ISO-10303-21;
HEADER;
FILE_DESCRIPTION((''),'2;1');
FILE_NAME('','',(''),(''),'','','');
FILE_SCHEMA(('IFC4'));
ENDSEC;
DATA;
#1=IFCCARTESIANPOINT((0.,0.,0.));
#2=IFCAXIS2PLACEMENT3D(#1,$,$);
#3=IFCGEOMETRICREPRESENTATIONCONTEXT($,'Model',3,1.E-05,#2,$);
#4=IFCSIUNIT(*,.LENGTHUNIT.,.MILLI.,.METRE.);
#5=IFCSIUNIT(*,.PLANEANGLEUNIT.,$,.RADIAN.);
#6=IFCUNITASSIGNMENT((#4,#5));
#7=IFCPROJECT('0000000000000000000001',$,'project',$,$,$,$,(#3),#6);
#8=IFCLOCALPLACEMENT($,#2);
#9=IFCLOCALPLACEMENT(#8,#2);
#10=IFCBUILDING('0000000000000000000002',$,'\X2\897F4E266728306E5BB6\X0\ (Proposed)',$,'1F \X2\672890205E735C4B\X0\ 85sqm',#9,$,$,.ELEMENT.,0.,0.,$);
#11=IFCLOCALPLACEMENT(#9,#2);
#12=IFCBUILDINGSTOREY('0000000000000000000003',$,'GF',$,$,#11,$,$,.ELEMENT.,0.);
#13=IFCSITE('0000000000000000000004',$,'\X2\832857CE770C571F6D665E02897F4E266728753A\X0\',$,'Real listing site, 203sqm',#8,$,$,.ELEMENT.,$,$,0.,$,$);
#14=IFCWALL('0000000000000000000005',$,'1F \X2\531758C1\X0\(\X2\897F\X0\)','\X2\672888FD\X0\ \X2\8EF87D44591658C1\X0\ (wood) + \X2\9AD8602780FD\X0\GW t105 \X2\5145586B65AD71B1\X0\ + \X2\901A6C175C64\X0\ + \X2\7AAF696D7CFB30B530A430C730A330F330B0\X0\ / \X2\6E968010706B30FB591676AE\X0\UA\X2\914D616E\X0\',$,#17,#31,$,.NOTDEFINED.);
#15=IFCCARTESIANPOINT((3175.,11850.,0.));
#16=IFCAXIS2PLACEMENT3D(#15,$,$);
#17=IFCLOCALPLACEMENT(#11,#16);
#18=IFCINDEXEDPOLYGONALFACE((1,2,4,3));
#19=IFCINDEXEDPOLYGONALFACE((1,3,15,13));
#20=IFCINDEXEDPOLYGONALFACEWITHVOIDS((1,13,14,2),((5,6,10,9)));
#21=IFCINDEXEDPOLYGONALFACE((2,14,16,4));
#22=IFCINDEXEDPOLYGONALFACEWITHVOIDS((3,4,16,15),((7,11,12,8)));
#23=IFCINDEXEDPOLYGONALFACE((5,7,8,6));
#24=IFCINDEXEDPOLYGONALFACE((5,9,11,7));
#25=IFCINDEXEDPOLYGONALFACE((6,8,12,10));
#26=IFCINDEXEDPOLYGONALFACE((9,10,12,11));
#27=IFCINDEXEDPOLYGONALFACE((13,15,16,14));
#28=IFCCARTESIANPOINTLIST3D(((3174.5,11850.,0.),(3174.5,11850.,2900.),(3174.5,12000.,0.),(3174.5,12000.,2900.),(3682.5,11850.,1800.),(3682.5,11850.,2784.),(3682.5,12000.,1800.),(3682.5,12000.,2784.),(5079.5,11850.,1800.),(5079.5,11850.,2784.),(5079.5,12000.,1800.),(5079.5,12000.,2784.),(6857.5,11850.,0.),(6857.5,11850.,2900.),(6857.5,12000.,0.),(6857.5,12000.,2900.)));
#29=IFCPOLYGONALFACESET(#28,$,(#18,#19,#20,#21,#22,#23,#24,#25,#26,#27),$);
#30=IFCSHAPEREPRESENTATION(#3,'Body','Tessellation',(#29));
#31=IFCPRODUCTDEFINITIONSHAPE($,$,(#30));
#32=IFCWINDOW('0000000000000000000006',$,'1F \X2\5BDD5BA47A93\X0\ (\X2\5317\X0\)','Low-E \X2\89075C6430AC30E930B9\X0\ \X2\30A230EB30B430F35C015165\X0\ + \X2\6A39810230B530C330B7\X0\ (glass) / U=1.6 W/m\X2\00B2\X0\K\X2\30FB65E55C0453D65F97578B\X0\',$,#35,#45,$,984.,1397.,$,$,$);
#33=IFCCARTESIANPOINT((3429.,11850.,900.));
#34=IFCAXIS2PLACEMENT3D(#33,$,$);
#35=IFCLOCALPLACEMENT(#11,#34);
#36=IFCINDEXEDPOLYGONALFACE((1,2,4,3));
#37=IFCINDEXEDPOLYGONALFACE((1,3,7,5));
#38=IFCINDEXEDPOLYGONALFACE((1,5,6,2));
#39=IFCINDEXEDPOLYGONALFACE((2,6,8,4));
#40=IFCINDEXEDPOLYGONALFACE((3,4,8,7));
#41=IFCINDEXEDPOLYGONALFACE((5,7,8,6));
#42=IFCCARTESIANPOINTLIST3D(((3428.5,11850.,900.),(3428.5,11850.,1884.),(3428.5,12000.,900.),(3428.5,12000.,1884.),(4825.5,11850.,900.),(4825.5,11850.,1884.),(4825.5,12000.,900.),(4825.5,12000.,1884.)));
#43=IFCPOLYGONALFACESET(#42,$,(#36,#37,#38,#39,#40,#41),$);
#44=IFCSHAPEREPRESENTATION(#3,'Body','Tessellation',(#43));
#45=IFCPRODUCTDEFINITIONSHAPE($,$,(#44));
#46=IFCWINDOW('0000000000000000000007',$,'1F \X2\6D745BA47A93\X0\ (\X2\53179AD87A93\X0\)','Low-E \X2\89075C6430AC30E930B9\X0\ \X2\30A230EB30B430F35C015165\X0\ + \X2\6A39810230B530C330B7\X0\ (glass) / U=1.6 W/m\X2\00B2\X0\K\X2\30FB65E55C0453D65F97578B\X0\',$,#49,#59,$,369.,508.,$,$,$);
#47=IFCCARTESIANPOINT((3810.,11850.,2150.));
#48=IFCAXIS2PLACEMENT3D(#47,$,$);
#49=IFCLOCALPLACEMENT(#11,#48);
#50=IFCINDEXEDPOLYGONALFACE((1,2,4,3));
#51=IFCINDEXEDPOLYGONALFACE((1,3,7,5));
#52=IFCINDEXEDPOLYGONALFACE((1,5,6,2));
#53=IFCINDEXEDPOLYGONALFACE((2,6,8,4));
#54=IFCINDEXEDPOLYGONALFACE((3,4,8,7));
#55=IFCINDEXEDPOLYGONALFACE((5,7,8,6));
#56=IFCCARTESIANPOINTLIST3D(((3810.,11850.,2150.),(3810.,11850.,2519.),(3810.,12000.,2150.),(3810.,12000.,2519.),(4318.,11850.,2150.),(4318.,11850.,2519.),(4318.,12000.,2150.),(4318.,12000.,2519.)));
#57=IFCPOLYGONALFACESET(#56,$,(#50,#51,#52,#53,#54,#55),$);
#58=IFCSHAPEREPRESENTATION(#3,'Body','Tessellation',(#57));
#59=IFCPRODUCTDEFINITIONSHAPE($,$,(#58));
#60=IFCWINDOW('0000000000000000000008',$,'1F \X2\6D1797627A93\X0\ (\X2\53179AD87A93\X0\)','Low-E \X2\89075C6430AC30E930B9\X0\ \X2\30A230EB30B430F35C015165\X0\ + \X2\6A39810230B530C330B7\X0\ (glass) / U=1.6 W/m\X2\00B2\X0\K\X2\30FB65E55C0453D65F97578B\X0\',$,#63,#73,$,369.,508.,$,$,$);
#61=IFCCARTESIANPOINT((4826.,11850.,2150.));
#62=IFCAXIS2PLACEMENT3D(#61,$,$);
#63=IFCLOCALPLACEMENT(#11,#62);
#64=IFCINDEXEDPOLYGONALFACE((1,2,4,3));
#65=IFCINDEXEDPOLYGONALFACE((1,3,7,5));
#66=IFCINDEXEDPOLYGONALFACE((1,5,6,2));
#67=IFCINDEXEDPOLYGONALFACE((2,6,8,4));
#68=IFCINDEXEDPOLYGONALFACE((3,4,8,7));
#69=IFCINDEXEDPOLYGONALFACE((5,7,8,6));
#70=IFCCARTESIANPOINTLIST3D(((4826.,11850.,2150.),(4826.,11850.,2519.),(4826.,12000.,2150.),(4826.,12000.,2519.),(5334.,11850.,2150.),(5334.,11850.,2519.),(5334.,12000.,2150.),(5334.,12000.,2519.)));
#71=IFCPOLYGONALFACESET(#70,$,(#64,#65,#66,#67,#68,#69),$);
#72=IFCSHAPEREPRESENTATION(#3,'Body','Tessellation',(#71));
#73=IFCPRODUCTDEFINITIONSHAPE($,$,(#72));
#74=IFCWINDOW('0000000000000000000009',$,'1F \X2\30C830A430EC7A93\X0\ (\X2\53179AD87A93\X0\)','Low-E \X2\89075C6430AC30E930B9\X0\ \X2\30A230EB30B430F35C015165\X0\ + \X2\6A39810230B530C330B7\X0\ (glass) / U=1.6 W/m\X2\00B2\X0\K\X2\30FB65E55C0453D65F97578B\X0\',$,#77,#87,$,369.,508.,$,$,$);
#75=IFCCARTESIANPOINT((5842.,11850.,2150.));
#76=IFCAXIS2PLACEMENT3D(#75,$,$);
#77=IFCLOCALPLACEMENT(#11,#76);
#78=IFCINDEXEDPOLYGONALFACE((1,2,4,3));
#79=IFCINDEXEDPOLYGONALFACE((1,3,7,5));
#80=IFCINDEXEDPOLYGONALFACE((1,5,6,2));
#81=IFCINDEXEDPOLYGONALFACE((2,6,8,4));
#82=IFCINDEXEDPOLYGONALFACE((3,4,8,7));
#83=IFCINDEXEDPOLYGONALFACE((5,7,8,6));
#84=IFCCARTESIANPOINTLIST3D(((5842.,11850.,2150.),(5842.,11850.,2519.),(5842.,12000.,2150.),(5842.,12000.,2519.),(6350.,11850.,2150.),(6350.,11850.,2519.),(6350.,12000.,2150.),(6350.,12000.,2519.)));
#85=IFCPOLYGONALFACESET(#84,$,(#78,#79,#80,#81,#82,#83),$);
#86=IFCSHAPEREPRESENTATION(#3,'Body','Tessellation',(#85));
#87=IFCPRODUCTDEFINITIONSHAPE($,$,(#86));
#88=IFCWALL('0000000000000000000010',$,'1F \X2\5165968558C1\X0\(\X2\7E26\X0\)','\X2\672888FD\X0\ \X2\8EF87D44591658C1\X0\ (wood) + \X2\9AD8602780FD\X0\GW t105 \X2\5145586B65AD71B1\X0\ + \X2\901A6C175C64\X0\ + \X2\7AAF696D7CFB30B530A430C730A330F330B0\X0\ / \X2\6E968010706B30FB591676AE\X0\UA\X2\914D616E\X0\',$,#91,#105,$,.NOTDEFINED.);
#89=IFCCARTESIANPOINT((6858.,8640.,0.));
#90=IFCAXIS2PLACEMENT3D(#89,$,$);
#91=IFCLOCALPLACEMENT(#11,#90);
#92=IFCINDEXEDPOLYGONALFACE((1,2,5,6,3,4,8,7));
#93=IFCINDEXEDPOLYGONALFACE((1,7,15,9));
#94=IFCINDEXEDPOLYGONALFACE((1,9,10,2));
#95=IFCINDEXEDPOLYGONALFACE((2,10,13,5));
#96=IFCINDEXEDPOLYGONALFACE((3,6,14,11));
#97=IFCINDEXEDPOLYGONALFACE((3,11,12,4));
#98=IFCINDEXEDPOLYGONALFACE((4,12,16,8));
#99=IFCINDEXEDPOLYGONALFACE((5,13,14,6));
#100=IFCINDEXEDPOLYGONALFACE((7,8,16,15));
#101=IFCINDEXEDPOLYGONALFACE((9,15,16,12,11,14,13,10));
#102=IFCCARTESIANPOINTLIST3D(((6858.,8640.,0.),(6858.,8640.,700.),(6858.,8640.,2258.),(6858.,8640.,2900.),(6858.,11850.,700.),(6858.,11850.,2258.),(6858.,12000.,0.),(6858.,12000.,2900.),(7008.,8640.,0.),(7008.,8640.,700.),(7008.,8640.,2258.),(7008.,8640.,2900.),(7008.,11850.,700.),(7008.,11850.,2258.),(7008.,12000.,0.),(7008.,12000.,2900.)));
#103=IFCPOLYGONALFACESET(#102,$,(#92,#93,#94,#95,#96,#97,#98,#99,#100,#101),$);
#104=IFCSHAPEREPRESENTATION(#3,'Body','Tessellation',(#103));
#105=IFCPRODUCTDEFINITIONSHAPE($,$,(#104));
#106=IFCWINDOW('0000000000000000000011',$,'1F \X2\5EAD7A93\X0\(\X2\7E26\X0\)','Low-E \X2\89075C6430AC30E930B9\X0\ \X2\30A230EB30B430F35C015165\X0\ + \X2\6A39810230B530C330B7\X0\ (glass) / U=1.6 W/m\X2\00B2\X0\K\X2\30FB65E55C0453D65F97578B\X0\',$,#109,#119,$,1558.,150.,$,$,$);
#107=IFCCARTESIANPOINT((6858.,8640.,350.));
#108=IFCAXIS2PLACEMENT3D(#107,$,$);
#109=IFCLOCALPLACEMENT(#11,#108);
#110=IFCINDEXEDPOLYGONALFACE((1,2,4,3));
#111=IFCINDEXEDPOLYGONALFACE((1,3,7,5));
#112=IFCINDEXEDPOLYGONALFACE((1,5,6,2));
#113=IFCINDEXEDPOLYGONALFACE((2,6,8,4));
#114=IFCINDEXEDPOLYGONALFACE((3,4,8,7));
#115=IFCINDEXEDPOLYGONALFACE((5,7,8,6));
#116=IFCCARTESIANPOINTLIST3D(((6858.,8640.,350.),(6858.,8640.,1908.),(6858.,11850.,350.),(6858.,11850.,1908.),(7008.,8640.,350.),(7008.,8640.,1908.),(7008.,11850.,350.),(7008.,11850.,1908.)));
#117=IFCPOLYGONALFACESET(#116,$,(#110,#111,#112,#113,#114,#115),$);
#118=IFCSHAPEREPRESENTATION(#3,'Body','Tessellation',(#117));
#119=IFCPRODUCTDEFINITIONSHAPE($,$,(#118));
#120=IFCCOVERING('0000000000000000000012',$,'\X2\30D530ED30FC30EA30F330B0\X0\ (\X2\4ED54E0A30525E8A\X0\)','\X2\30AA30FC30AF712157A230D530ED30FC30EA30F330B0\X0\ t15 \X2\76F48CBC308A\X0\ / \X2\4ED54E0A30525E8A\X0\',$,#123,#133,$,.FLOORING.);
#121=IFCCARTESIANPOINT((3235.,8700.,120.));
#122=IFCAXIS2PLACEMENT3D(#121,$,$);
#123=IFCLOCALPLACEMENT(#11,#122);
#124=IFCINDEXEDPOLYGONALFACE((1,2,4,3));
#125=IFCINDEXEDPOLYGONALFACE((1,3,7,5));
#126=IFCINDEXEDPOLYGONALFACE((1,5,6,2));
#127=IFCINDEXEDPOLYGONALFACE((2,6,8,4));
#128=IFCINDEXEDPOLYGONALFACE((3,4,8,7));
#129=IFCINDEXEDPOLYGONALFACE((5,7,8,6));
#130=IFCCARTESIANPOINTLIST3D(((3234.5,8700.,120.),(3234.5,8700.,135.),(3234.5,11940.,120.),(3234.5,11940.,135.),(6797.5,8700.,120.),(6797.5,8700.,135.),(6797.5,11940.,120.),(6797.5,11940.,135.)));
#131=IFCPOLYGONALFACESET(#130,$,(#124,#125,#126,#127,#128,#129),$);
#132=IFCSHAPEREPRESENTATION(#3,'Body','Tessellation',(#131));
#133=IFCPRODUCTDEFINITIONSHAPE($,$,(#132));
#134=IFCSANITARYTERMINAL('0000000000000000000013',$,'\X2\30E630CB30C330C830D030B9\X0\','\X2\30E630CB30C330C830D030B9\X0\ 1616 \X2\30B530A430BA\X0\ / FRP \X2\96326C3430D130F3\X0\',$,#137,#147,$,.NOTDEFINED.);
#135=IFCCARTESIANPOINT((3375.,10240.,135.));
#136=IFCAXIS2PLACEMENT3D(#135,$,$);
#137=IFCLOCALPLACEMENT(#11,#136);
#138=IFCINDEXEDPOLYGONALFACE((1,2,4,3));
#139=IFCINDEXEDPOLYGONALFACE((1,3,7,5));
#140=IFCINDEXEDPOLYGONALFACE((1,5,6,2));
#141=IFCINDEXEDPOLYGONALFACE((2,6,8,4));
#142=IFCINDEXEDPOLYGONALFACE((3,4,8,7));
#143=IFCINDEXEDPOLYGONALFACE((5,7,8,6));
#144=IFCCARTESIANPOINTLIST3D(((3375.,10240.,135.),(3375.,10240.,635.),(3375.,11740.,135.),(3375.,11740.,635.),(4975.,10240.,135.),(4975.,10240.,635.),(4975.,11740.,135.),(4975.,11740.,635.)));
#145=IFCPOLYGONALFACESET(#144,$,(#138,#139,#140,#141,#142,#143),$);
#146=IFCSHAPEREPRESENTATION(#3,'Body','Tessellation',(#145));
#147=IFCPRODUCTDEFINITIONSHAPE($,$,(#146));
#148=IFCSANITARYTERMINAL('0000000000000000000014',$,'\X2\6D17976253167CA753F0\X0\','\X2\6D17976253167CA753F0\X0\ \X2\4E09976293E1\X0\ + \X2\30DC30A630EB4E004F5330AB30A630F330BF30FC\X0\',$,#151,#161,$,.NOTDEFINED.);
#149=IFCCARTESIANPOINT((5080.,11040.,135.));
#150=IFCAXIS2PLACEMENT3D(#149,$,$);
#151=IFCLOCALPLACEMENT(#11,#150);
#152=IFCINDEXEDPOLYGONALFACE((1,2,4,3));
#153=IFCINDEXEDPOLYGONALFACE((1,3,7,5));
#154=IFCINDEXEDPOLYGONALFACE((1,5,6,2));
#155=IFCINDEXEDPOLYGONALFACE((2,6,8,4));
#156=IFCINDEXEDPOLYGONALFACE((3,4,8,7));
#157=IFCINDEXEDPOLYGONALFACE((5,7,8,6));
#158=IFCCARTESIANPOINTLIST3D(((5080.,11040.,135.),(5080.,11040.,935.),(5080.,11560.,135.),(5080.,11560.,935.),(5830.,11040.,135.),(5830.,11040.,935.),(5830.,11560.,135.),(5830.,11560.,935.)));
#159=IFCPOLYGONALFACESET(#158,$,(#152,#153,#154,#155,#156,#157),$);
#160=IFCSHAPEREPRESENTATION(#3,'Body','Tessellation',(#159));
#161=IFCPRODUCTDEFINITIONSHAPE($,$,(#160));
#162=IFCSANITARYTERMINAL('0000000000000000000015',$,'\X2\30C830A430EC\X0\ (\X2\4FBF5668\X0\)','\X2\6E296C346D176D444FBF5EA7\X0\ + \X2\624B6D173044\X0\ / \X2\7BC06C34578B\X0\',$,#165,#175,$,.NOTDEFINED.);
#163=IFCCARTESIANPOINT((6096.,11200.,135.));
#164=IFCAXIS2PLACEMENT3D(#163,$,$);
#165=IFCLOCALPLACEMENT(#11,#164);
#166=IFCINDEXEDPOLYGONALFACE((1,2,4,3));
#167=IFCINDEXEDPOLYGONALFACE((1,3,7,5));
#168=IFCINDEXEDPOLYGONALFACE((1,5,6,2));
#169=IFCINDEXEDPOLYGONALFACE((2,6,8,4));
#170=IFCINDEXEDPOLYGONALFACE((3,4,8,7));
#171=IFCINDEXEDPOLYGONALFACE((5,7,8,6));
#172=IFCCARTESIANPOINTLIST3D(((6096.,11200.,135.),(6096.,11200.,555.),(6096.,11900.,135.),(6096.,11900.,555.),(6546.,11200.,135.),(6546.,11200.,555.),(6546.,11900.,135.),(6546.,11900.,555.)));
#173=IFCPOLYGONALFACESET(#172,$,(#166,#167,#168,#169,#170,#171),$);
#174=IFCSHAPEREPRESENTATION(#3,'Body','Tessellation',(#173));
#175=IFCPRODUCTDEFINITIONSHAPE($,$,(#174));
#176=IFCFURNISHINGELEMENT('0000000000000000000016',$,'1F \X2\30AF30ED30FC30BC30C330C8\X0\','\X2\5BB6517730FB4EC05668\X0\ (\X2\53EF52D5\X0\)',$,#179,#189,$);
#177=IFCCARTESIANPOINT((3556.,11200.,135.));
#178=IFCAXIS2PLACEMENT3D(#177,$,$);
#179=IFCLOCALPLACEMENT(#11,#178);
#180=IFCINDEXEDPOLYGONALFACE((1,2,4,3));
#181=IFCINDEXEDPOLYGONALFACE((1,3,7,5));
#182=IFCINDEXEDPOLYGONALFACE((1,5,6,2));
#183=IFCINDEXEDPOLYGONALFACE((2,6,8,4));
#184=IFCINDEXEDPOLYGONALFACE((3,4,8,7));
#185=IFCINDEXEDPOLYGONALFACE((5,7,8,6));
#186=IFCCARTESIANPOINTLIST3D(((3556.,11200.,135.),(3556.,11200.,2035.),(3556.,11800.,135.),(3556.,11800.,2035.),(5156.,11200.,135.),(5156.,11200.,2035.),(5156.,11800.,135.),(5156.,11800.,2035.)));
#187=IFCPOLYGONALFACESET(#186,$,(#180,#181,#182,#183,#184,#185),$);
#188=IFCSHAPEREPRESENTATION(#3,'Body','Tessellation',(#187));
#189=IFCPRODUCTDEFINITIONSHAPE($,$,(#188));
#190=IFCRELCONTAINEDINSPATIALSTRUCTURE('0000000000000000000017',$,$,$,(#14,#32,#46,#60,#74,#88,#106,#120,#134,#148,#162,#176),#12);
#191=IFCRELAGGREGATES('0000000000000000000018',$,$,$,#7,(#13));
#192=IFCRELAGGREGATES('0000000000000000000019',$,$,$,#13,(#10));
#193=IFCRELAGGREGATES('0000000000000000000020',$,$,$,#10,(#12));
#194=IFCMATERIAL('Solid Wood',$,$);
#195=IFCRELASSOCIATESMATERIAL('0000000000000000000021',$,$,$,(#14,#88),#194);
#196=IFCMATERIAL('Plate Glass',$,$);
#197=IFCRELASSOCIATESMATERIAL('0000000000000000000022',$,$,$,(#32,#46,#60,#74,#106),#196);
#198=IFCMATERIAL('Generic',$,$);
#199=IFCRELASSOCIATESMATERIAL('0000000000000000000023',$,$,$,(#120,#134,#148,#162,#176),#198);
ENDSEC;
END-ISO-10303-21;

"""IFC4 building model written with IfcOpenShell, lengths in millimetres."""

from ifc_helpers import new_model, si_unit, frame, frame_2d, origin, place, context, project, spatial, rectangle, extrude, material, element, fill, save


model = new_model("IFC4")

# Units and contexts
model_context = context("Model", 3, precision=1e-05, world=origin())
ifc_project = project(units=[si_unit("LENGTHUNIT", "METRE", prefix="MILLI"), si_unit("PLANEANGLEUNIT", "RADIAN")], contexts=[model_context])

# Site, building, storey
site_placement = place(None, origin())
site = spatial("IfcSite", under=ifc_project, at=site_placement, Name="茨城県土浦市西並木町", ObjectType="Real listing site, 203sqm", CompositionType="ELEMENT", RefElevation=0.0)
building_placement = place(site_placement, origin())
building = spatial("IfcBuilding", under=site, at=building_placement, Name="西並木の家 (Proposed)", ObjectType="1F 木造平屋 85sqm", CompositionType="ELEMENT", ElevationOfRefHeight=0.0, ElevationOfTerrain=0.0)
storey_placement = place(building_placement, origin())
storey = spatial("IfcBuildingStorey", under=building, at=storey_placement, Name="GF", CompositionType="ELEMENT", Elevation=0.0)

# Shared definitions
ifc_material_1 = material(Name="Solid Wood")

# Wall, openings, windows
wall_1_placement = place(storey_placement, frame((3175.0, 11850.0, 0.0)))
wall_1 = element("IfcWall", 1, at=wall_1_placement, inside=storey, material=ifc_material_1, Name="1F 北壁(西)", Description="木製 軸組外壁 (wood) + 高性能GW t105 充填断熱 + 通気層 + 窯業系サイディング / 準耐火・外皮UA配慮", PredefinedType="NOTDEFINED", context=model_context, shape_type="SweptSolid", body=[
    extrude(rectangle(XDim=3683.0, YDim=150.0, at=frame_2d((1841.0, 75.0))), frame((3175.0, 11850.0, 0.0)), (0.0, 0.0, 1.0), 2900.0),
])
opening_1_placement = place(storey_placement, frame((3429.0, 11850.0, 900.0)))
opening_1 = element("IfcOpeningElement", 2, at=opening_1_placement, cuts=wall_1, PredefinedType="NOTDEFINED", context=model_context, shape_type="SweptSolid", body=[
    extrude(rectangle(XDim=1397.0, YDim=150.0, at=frame_2d((698.0, 75.0))), frame((3429.0, 11850.0, 900.0)), (0.0, 0.0, 1.0), 984.0),
])
opening_2_placement = place(storey_placement, frame((3810.0, 11850.0, 2150.0)))
opening_2 = element("IfcOpeningElement", 3, at=opening_2_placement, cuts=wall_1, PredefinedType="NOTDEFINED", context=model_context, shape_type="SweptSolid", body=[
    extrude(rectangle(XDim=508.0, YDim=150.0, at=frame_2d((254.0, 75.0))), frame((3810.0, 11850.0, 2150.0)), (0.0, 0.0, 1.0), 369.0),
])
opening_3_placement = place(storey_placement, frame((4826.0, 11850.0, 2150.0)))
opening_3 = element("IfcOpeningElement", 4, at=opening_3_placement, cuts=wall_1, PredefinedType="NOTDEFINED", context=model_context, shape_type="SweptSolid", body=[
    extrude(rectangle(XDim=508.0, YDim=150.0, at=frame_2d((254.0, 75.0))), frame((4826.0, 11850.0, 2150.0)), (0.0, 0.0, 1.0), 369.0),
])
opening_4_placement = place(storey_placement, frame((5842.0, 11850.0, 2150.0)))
opening_4 = element("IfcOpeningElement", 5, at=opening_4_placement, cuts=wall_1, PredefinedType="NOTDEFINED", context=model_context, shape_type="SweptSolid", body=[
    extrude(rectangle(XDim=508.0, YDim=150.0, at=frame_2d((254.0, 75.0))), frame((5842.0, 11850.0, 2150.0)), (0.0, 0.0, 1.0), 369.0),
])
ifc_material_2 = material(Name="Plate Glass")
window_1_placement = place(storey_placement, frame((3429.0, 11850.0, 900.0)))
window_1 = element("IfcWindow", 6, at=window_1_placement, inside=storey, material=ifc_material_2, Name="1F 寝室窓 (北)", Description="Low-E 複層ガラス アルゴン封入 + 樹脂サッシ (glass) / U=1.6 W/m²K・日射取得型", OverallHeight=984.0, OverallWidth=1397.0, context=model_context, shape_type="SweptSolid", body=[
    extrude(rectangle(XDim=1397.0, YDim=150.0, at=frame_2d((698.0, 75.0))), frame((3429.0, 11850.0, 900.0)), (0.0, 0.0, 1.0), 984.0),
])
fill(opening_1, window_1)
window_2_placement = place(storey_placement, frame((3810.0, 11850.0, 2150.0)))
window_2 = element("IfcWindow", 7, at=window_2_placement, inside=storey, material=ifc_material_2, Name="1F 浴室窓 (北高窓)", Description="Low-E 複層ガラス アルゴン封入 + 樹脂サッシ (glass) / U=1.6 W/m²K・日射取得型", OverallHeight=369.0, OverallWidth=508.0, context=model_context, shape_type="SweptSolid", body=[
    extrude(rectangle(XDim=508.0, YDim=150.0, at=frame_2d((254.0, 75.0))), frame((3810.0, 11850.0, 2150.0)), (0.0, 0.0, 1.0), 369.0),
])
fill(opening_2, window_2)
window_3_placement = place(storey_placement, frame((4826.0, 11850.0, 2150.0)))
window_3 = element("IfcWindow", 8, at=window_3_placement, inside=storey, material=ifc_material_2, Name="1F 洗面窓 (北高窓)", Description="Low-E 複層ガラス アルゴン封入 + 樹脂サッシ (glass) / U=1.6 W/m²K・日射取得型", OverallHeight=369.0, OverallWidth=508.0, context=model_context, shape_type="SweptSolid", body=[
    extrude(rectangle(XDim=508.0, YDim=150.0, at=frame_2d((254.0, 75.0))), frame((4826.0, 11850.0, 2150.0)), (0.0, 0.0, 1.0), 369.0),
])
fill(opening_3, window_3)
window_4_placement = place(storey_placement, frame((5842.0, 11850.0, 2150.0)))
window_4 = element("IfcWindow", 9, at=window_4_placement, inside=storey, material=ifc_material_2, Name="1F トイレ窓 (北高窓)", Description="Low-E 複層ガラス アルゴン封入 + 樹脂サッシ (glass) / U=1.6 W/m²K・日射取得型", OverallHeight=369.0, OverallWidth=508.0, context=model_context, shape_type="SweptSolid", body=[
    extrude(rectangle(XDim=508.0, YDim=150.0, at=frame_2d((254.0, 75.0))), frame((5842.0, 11850.0, 2150.0)), (0.0, 0.0, 1.0), 369.0),
])
fill(opening_4, window_4)

# Wall, opening, window
wall_2_placement = place(storey_placement, frame((6858.0, 8640.0, 0.0)))
wall_2 = element("IfcWall", 10, at=wall_2_placement, inside=storey, material=ifc_material_1, Name="1F 入隅壁(縦)", Description="木製 軸組外壁 (wood) + 高性能GW t105 充填断熱 + 通気層 + 窯業系サイディング / 準耐火・外皮UA配慮", PredefinedType="NOTDEFINED", context=model_context, shape_type="SweptSolid", body=[
    extrude(rectangle(XDim=150.0, YDim=3360.0, at=frame_2d((75.0, 1680.0))), frame((6858.0, 8640.0, 0.0)), (0.0, 0.0, 1.0), 2900.0),
])
opening_5_placement = place(storey_placement, frame((6858.0, 8640.0, 350.0)))
opening_5 = element("IfcOpeningElement", 11, at=opening_5_placement, cuts=wall_2, PredefinedType="NOTDEFINED", context=model_context, shape_type="SweptSolid", body=[
    extrude(rectangle(XDim=150.0, YDim=3210.0, at=frame_2d((75.0, 1605.0))), frame((6858.0, 8640.0, 350.0)), (0.0, 0.0, 1.0), 1558.0),
])
window_5_placement = place(storey_placement, frame((6858.0, 8640.0, 350.0)))
window_5 = element("IfcWindow", 12, at=window_5_placement, inside=storey, material=ifc_material_2, Name="1F 庭窓(縦)", Description="Low-E 複層ガラス アルゴン封入 + 樹脂サッシ (glass) / U=1.6 W/m²K・日射取得型", OverallHeight=1558.0, OverallWidth=150.0, context=model_context, shape_type="SweptSolid", body=[
    extrude(rectangle(XDim=150.0, YDim=3210.0, at=frame_2d((75.0, 1605.0))), frame((6858.0, 8640.0, 350.0)), (0.0, 0.0, 1.0), 1558.0),
])
fill(opening_5, window_5)

# Covering
ifc_material_3 = material(Name="Generic")
covering_placement = place(storey_placement, frame((3235.0, 8700.0, 120.0)))
element("IfcCovering", 13, at=covering_placement, inside=storey, material=ifc_material_3, Name="フローリング (仕上げ床)", Description="オーク無垢フローリング t15 直貼り / 仕上げ床", PredefinedType="FLOORING", context=model_context, shape_type="SweptSolid", body=[
    extrude(rectangle(XDim=3563.0, YDim=3240.0, at=frame_2d((1781.0, 1620.0))), frame((3235.0, 8700.0, 120.0)), (0.0, 0.0, 1.0), 15.0),
])

# Sanitary terminals
sanitary_terminal_1_placement = place(storey_placement, frame((3375.0, 10240.0, 135.0)))
element("IfcSanitaryTerminal", 14, at=sanitary_terminal_1_placement, inside=storey, material=ifc_material_3, Name="ユニットバス", Description="ユニットバス 1616 サイズ / FRP 防水パン", PredefinedType="NOTDEFINED", context=model_context, shape_type="SweptSolid", body=[
    extrude(rectangle(XDim=1600.0, YDim=1500.0, at=frame_2d((800.0, 750.0))), frame((3375.0, 10240.0, 135.0)), (0.0, 0.0, 1.0), 500.0),
])
sanitary_terminal_2_placement = place(storey_placement, frame((5080.0, 11040.0, 135.0)))
element("IfcSanitaryTerminal", 15, at=sanitary_terminal_2_placement, inside=storey, material=ifc_material_3, Name="洗面化粧台", Description="洗面化粧台 三面鏡 + ボウル一体カウンター", PredefinedType="NOTDEFINED", context=model_context, shape_type="SweptSolid", body=[
    extrude(rectangle(XDim=750.0, YDim=520.0, at=frame_2d((375.0, 260.0))), frame((5080.0, 11040.0, 135.0)), (0.0, 0.0, 1.0), 800.0),
])
sanitary_terminal_3_placement = place(storey_placement, frame((6096.0, 11200.0, 135.0)))
element("IfcSanitaryTerminal", 16, at=sanitary_terminal_3_placement, inside=storey, material=ifc_material_3, Name="トイレ (便器)", Description="温水洗浄便座 + 手洗い / 節水型", PredefinedType="NOTDEFINED", context=model_context, shape_type="SweptSolid", body=[
    extrude(rectangle(XDim=450.0, YDim=700.0, at=frame_2d((225.0, 350.0))), frame((6096.0, 11200.0, 135.0)), (0.0, 0.0, 1.0), 420.0),
])

# Furnishing element
furnishing_1_placement = place(storey_placement, frame((3556.0, 11200.0, 135.0)))
element("IfcFurnishingElement", 17, at=furnishing_1_placement, inside=storey, material=ifc_material_3, Name="1F クローゼット", Description="家具・什器 (可動)", context=model_context, shape_type="SweptSolid", body=[
    extrude(rectangle(XDim=1600.0, YDim=600.0, at=frame_2d((800.0, 300.0))), frame((3556.0, 11200.0, 135.0)), (0.0, 0.0, 1.0), 1900.0),
])

save(model, "model.ifc")
